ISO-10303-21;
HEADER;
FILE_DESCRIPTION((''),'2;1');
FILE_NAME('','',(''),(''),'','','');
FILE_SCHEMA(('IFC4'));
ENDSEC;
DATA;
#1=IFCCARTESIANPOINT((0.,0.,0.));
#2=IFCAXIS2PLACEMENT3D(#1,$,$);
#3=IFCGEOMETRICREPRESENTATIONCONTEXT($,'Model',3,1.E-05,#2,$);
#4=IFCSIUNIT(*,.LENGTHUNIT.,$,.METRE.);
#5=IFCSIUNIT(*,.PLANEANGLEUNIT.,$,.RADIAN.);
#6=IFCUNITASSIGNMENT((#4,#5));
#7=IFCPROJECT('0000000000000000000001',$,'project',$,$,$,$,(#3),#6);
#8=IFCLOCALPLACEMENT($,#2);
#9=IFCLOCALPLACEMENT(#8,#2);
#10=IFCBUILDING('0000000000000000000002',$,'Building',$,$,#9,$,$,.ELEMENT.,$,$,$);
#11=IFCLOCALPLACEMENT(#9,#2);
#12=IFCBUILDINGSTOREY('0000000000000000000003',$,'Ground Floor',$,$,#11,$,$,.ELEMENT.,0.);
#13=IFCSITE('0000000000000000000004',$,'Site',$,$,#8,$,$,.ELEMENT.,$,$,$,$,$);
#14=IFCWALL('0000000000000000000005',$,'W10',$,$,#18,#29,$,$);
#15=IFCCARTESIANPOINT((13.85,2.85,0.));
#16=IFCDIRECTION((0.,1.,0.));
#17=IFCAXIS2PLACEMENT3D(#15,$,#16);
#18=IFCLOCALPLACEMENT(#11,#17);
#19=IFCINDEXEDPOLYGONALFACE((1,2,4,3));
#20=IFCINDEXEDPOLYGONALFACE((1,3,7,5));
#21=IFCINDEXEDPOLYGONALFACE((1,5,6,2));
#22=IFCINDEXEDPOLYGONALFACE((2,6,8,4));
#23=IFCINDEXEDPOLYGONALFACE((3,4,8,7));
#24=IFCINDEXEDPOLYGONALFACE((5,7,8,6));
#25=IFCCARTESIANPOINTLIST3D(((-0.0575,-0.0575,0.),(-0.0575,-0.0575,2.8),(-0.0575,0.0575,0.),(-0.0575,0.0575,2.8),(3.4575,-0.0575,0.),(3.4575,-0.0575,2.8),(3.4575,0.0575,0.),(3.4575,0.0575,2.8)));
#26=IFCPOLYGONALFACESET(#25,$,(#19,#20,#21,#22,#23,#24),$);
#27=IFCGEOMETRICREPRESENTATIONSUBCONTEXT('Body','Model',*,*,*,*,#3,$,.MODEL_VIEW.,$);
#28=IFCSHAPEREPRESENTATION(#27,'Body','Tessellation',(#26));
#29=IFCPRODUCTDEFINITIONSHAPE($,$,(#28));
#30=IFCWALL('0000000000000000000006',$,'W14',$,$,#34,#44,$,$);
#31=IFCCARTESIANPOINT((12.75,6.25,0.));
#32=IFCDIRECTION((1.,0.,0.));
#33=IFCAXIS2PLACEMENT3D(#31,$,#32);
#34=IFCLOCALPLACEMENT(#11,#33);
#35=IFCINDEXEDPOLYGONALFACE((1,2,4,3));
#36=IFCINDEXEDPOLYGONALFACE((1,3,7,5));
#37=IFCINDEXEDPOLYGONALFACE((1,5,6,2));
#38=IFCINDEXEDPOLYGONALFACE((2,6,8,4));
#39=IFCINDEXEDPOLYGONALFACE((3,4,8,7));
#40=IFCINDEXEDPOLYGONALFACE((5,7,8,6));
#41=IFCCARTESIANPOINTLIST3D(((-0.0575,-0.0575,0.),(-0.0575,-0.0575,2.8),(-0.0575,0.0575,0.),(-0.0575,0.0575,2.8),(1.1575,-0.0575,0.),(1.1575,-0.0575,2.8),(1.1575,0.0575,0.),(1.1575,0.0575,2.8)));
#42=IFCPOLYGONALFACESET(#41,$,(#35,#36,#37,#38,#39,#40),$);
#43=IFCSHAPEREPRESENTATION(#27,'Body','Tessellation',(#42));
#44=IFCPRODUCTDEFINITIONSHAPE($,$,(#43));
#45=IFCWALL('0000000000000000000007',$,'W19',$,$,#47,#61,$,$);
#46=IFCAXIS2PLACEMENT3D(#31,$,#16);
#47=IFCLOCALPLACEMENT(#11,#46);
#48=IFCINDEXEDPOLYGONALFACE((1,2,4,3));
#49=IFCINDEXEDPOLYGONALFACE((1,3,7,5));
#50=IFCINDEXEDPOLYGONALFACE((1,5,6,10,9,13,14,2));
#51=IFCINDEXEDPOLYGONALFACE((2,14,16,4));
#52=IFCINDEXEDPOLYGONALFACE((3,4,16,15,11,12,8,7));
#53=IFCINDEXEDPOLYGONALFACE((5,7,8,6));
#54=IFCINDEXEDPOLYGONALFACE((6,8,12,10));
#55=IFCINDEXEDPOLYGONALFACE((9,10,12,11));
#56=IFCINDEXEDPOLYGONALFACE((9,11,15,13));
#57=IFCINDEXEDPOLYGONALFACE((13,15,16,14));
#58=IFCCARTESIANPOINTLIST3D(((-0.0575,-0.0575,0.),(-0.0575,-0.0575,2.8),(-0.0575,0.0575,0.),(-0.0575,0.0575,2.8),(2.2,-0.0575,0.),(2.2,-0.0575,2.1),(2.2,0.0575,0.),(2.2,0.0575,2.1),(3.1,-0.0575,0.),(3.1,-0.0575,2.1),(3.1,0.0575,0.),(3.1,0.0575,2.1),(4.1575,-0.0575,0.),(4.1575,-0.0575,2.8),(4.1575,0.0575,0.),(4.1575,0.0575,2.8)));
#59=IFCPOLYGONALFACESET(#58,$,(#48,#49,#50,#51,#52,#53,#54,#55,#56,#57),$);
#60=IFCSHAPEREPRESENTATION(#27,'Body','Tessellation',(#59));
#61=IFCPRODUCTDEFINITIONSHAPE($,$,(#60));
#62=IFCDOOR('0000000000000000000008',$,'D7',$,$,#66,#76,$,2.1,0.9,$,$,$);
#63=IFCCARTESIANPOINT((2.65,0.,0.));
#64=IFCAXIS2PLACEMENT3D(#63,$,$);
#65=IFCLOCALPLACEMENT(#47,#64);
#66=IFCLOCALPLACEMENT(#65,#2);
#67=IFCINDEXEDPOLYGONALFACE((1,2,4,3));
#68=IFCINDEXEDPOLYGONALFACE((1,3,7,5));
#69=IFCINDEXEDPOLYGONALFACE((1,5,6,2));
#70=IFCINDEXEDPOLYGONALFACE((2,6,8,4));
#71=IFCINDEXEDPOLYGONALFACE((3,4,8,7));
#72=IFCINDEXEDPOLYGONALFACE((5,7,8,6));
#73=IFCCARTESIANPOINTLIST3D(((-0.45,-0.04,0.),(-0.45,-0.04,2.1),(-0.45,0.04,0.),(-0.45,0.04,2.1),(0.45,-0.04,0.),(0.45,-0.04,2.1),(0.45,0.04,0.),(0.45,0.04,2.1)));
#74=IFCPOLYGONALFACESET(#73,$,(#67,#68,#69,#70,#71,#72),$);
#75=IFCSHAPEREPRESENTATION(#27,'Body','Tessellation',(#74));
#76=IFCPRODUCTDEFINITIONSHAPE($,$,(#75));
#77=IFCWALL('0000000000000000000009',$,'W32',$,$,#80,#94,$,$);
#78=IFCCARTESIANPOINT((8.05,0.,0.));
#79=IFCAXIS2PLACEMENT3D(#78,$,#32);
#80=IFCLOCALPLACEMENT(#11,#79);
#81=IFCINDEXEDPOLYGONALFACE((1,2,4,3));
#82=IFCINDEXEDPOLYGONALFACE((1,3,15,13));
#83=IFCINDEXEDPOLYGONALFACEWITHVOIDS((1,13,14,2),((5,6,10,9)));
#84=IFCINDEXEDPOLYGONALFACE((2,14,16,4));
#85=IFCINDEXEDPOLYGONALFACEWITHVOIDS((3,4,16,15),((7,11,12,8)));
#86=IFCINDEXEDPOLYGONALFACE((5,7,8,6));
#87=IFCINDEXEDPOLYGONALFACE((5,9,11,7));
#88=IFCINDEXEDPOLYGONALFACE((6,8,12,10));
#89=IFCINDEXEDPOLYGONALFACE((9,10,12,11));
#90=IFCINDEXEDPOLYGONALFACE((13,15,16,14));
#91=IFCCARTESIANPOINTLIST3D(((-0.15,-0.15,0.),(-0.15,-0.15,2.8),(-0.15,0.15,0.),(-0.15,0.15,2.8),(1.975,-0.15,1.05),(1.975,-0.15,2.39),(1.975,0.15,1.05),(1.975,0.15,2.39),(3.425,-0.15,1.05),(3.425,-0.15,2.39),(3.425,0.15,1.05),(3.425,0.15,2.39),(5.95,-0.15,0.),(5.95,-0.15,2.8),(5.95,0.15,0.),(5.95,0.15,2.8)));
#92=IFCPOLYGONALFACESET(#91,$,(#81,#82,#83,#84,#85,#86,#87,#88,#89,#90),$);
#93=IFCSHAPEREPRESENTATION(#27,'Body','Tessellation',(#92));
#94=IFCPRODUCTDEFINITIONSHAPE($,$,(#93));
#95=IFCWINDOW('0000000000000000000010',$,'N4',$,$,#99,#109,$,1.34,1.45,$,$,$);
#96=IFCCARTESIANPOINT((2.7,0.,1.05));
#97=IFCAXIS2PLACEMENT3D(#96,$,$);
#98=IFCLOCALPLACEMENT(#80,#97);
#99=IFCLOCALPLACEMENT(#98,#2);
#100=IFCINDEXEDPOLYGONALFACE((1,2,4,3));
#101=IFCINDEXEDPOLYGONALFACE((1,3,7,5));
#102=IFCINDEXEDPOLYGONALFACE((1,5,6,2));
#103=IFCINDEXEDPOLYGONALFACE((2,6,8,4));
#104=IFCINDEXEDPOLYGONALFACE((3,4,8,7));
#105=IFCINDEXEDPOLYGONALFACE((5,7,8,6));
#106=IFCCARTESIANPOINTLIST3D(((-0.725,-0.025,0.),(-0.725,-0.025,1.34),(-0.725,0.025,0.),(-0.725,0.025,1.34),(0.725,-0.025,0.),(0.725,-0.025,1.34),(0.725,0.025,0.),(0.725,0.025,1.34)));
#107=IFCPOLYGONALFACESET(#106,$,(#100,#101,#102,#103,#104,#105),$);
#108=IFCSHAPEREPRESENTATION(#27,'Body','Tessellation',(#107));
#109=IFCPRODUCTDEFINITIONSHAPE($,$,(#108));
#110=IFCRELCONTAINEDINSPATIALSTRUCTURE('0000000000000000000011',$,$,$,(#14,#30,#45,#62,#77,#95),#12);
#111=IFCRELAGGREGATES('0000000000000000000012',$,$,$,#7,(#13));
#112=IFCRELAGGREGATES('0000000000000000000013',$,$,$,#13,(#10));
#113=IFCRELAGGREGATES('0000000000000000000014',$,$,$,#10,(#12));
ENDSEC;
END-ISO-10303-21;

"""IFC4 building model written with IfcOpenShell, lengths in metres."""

from ifc_helpers import new_model, si_unit, frame, frame_2d, origin, origin_2d, place, context, subcontext, project, spatial, rectangle, extrude, element, fill, save


model = new_model("IFC4")

# Units and contexts
model_context = context("Model", 3, precision=1e-05, world=origin())
body_context = subcontext(model_context, "Body", "Model", "MODEL_VIEW")
ifc_project = project(units=[si_unit("LENGTHUNIT", "METRE"), si_unit("PLANEANGLEUNIT", "RADIAN")], contexts=[model_context])

# Site, building, storey
site_placement = place(None, origin())
site = spatial("IfcSite", under=ifc_project, at=site_placement, Name="Site", CompositionType="ELEMENT")
building_placement = place(site_placement, origin())
building = spatial("IfcBuilding", under=site, at=building_placement, Name="Building", CompositionType="ELEMENT")
storey_placement = place(building_placement, origin())
storey = spatial("IfcBuildingStorey", under=building, at=storey_placement, Name="Ground Floor", CompositionType="ELEMENT", Elevation=0.0)

# Wall
wall_1_placement = place(storey_placement, frame((13.85, 2.85, 0.0), x_axis=(0.0, 1.0, 0.0)))
element("IfcWall", 1, at=wall_1_placement, inside=storey, Name="W10", context=body_context, shape_type="SweptSolid", body=[
    extrude(rectangle(XDim=3.515, YDim=0.115, at=frame_2d((1.7, 0.0))), origin(), (0.0, 0.0, 1.0), 2.8),
])

# Wall
wall_2_placement = place(storey_placement, frame((12.75, 6.25, 0.0), x_axis=(1.0, 0.0, 0.0)))
element("IfcWall", 2, at=wall_2_placement, inside=storey, Name="W14", context=body_context, shape_type="SweptSolid", body=[
    extrude(rectangle(XDim=1.215, YDim=0.115, at=frame_2d((0.55, 0.0))), origin(), (0.0, 0.0, 1.0), 2.8),
])

# Wall, opening, door
wall_3_placement = place(storey_placement, frame((12.75, 6.25, 0.0), x_axis=(0.0, 1.0, 0.0)))
wall_3 = element("IfcWall", 3, at=wall_3_placement, inside=storey, Name="W19", context=body_context, shape_type="SweptSolid", body=[
    extrude(rectangle(XDim=4.215, YDim=0.115, at=frame_2d((2.05, 0.0))), origin(), (0.0, 0.0, 1.0), 2.8),
])
opening_1_placement = place(wall_3_placement, frame((2.65, 0.0, 0.0)))
opening_1 = element("IfcOpeningElement", 4, at=opening_1_placement, cuts=wall_3, context=body_context, shape_type="SweptSolid", body=[
    extrude(rectangle(XDim=0.9, YDim=0.215, at=origin_2d()), origin(), (0.0, 0.0, 1.0), 2.1),
])
door_1_placement = place(opening_1_placement, origin())
door_1 = element("IfcDoor", 5, at=door_1_placement, inside=storey, Name="D7", OverallHeight=2.1, OverallWidth=0.9, context=body_context, shape_type="SweptSolid", body=[
    extrude(rectangle(XDim=0.9, YDim=0.08, at=origin_2d()), origin(), (0.0, 0.0, 1.0), 2.1),
])
fill(opening_1, door_1)

# Wall, opening, window
wall_4_placement = place(storey_placement, frame((8.05, 0.0, 0.0), x_axis=(1.0, 0.0, 0.0)))
wall_4 = element("IfcWall", 6, at=wall_4_placement, inside=storey, Name="W32", context=body_context, shape_type="SweptSolid", body=[
    extrude(rectangle(XDim=6.1, YDim=0.3, at=frame_2d((2.9, 0.0))), origin(), (0.0, 0.0, 1.0), 2.8),
])
opening_2_placement = place(wall_4_placement, frame((2.7, 0.0, 1.05)))
opening_2 = element("IfcOpeningElement", 7, at=opening_2_placement, cuts=wall_4, context=body_context, shape_type="SweptSolid", body=[
    extrude(rectangle(XDim=1.45, YDim=0.4, at=origin_2d()), origin(), (0.0, 0.0, 1.0), 1.34),
])
window_1_placement = place(opening_2_placement, origin())
window_1 = element("IfcWindow", 8, at=window_1_placement, inside=storey, Name="N4", OverallHeight=1.34, OverallWidth=1.45, context=body_context, shape_type="SweptSolid", body=[
    extrude(rectangle(XDim=1.45, YDim=0.05, at=origin_2d()), origin(), (0.0, 0.0, 1.0), 1.34),
])
fill(opening_2, window_1)

save(model, "model.ifc")
